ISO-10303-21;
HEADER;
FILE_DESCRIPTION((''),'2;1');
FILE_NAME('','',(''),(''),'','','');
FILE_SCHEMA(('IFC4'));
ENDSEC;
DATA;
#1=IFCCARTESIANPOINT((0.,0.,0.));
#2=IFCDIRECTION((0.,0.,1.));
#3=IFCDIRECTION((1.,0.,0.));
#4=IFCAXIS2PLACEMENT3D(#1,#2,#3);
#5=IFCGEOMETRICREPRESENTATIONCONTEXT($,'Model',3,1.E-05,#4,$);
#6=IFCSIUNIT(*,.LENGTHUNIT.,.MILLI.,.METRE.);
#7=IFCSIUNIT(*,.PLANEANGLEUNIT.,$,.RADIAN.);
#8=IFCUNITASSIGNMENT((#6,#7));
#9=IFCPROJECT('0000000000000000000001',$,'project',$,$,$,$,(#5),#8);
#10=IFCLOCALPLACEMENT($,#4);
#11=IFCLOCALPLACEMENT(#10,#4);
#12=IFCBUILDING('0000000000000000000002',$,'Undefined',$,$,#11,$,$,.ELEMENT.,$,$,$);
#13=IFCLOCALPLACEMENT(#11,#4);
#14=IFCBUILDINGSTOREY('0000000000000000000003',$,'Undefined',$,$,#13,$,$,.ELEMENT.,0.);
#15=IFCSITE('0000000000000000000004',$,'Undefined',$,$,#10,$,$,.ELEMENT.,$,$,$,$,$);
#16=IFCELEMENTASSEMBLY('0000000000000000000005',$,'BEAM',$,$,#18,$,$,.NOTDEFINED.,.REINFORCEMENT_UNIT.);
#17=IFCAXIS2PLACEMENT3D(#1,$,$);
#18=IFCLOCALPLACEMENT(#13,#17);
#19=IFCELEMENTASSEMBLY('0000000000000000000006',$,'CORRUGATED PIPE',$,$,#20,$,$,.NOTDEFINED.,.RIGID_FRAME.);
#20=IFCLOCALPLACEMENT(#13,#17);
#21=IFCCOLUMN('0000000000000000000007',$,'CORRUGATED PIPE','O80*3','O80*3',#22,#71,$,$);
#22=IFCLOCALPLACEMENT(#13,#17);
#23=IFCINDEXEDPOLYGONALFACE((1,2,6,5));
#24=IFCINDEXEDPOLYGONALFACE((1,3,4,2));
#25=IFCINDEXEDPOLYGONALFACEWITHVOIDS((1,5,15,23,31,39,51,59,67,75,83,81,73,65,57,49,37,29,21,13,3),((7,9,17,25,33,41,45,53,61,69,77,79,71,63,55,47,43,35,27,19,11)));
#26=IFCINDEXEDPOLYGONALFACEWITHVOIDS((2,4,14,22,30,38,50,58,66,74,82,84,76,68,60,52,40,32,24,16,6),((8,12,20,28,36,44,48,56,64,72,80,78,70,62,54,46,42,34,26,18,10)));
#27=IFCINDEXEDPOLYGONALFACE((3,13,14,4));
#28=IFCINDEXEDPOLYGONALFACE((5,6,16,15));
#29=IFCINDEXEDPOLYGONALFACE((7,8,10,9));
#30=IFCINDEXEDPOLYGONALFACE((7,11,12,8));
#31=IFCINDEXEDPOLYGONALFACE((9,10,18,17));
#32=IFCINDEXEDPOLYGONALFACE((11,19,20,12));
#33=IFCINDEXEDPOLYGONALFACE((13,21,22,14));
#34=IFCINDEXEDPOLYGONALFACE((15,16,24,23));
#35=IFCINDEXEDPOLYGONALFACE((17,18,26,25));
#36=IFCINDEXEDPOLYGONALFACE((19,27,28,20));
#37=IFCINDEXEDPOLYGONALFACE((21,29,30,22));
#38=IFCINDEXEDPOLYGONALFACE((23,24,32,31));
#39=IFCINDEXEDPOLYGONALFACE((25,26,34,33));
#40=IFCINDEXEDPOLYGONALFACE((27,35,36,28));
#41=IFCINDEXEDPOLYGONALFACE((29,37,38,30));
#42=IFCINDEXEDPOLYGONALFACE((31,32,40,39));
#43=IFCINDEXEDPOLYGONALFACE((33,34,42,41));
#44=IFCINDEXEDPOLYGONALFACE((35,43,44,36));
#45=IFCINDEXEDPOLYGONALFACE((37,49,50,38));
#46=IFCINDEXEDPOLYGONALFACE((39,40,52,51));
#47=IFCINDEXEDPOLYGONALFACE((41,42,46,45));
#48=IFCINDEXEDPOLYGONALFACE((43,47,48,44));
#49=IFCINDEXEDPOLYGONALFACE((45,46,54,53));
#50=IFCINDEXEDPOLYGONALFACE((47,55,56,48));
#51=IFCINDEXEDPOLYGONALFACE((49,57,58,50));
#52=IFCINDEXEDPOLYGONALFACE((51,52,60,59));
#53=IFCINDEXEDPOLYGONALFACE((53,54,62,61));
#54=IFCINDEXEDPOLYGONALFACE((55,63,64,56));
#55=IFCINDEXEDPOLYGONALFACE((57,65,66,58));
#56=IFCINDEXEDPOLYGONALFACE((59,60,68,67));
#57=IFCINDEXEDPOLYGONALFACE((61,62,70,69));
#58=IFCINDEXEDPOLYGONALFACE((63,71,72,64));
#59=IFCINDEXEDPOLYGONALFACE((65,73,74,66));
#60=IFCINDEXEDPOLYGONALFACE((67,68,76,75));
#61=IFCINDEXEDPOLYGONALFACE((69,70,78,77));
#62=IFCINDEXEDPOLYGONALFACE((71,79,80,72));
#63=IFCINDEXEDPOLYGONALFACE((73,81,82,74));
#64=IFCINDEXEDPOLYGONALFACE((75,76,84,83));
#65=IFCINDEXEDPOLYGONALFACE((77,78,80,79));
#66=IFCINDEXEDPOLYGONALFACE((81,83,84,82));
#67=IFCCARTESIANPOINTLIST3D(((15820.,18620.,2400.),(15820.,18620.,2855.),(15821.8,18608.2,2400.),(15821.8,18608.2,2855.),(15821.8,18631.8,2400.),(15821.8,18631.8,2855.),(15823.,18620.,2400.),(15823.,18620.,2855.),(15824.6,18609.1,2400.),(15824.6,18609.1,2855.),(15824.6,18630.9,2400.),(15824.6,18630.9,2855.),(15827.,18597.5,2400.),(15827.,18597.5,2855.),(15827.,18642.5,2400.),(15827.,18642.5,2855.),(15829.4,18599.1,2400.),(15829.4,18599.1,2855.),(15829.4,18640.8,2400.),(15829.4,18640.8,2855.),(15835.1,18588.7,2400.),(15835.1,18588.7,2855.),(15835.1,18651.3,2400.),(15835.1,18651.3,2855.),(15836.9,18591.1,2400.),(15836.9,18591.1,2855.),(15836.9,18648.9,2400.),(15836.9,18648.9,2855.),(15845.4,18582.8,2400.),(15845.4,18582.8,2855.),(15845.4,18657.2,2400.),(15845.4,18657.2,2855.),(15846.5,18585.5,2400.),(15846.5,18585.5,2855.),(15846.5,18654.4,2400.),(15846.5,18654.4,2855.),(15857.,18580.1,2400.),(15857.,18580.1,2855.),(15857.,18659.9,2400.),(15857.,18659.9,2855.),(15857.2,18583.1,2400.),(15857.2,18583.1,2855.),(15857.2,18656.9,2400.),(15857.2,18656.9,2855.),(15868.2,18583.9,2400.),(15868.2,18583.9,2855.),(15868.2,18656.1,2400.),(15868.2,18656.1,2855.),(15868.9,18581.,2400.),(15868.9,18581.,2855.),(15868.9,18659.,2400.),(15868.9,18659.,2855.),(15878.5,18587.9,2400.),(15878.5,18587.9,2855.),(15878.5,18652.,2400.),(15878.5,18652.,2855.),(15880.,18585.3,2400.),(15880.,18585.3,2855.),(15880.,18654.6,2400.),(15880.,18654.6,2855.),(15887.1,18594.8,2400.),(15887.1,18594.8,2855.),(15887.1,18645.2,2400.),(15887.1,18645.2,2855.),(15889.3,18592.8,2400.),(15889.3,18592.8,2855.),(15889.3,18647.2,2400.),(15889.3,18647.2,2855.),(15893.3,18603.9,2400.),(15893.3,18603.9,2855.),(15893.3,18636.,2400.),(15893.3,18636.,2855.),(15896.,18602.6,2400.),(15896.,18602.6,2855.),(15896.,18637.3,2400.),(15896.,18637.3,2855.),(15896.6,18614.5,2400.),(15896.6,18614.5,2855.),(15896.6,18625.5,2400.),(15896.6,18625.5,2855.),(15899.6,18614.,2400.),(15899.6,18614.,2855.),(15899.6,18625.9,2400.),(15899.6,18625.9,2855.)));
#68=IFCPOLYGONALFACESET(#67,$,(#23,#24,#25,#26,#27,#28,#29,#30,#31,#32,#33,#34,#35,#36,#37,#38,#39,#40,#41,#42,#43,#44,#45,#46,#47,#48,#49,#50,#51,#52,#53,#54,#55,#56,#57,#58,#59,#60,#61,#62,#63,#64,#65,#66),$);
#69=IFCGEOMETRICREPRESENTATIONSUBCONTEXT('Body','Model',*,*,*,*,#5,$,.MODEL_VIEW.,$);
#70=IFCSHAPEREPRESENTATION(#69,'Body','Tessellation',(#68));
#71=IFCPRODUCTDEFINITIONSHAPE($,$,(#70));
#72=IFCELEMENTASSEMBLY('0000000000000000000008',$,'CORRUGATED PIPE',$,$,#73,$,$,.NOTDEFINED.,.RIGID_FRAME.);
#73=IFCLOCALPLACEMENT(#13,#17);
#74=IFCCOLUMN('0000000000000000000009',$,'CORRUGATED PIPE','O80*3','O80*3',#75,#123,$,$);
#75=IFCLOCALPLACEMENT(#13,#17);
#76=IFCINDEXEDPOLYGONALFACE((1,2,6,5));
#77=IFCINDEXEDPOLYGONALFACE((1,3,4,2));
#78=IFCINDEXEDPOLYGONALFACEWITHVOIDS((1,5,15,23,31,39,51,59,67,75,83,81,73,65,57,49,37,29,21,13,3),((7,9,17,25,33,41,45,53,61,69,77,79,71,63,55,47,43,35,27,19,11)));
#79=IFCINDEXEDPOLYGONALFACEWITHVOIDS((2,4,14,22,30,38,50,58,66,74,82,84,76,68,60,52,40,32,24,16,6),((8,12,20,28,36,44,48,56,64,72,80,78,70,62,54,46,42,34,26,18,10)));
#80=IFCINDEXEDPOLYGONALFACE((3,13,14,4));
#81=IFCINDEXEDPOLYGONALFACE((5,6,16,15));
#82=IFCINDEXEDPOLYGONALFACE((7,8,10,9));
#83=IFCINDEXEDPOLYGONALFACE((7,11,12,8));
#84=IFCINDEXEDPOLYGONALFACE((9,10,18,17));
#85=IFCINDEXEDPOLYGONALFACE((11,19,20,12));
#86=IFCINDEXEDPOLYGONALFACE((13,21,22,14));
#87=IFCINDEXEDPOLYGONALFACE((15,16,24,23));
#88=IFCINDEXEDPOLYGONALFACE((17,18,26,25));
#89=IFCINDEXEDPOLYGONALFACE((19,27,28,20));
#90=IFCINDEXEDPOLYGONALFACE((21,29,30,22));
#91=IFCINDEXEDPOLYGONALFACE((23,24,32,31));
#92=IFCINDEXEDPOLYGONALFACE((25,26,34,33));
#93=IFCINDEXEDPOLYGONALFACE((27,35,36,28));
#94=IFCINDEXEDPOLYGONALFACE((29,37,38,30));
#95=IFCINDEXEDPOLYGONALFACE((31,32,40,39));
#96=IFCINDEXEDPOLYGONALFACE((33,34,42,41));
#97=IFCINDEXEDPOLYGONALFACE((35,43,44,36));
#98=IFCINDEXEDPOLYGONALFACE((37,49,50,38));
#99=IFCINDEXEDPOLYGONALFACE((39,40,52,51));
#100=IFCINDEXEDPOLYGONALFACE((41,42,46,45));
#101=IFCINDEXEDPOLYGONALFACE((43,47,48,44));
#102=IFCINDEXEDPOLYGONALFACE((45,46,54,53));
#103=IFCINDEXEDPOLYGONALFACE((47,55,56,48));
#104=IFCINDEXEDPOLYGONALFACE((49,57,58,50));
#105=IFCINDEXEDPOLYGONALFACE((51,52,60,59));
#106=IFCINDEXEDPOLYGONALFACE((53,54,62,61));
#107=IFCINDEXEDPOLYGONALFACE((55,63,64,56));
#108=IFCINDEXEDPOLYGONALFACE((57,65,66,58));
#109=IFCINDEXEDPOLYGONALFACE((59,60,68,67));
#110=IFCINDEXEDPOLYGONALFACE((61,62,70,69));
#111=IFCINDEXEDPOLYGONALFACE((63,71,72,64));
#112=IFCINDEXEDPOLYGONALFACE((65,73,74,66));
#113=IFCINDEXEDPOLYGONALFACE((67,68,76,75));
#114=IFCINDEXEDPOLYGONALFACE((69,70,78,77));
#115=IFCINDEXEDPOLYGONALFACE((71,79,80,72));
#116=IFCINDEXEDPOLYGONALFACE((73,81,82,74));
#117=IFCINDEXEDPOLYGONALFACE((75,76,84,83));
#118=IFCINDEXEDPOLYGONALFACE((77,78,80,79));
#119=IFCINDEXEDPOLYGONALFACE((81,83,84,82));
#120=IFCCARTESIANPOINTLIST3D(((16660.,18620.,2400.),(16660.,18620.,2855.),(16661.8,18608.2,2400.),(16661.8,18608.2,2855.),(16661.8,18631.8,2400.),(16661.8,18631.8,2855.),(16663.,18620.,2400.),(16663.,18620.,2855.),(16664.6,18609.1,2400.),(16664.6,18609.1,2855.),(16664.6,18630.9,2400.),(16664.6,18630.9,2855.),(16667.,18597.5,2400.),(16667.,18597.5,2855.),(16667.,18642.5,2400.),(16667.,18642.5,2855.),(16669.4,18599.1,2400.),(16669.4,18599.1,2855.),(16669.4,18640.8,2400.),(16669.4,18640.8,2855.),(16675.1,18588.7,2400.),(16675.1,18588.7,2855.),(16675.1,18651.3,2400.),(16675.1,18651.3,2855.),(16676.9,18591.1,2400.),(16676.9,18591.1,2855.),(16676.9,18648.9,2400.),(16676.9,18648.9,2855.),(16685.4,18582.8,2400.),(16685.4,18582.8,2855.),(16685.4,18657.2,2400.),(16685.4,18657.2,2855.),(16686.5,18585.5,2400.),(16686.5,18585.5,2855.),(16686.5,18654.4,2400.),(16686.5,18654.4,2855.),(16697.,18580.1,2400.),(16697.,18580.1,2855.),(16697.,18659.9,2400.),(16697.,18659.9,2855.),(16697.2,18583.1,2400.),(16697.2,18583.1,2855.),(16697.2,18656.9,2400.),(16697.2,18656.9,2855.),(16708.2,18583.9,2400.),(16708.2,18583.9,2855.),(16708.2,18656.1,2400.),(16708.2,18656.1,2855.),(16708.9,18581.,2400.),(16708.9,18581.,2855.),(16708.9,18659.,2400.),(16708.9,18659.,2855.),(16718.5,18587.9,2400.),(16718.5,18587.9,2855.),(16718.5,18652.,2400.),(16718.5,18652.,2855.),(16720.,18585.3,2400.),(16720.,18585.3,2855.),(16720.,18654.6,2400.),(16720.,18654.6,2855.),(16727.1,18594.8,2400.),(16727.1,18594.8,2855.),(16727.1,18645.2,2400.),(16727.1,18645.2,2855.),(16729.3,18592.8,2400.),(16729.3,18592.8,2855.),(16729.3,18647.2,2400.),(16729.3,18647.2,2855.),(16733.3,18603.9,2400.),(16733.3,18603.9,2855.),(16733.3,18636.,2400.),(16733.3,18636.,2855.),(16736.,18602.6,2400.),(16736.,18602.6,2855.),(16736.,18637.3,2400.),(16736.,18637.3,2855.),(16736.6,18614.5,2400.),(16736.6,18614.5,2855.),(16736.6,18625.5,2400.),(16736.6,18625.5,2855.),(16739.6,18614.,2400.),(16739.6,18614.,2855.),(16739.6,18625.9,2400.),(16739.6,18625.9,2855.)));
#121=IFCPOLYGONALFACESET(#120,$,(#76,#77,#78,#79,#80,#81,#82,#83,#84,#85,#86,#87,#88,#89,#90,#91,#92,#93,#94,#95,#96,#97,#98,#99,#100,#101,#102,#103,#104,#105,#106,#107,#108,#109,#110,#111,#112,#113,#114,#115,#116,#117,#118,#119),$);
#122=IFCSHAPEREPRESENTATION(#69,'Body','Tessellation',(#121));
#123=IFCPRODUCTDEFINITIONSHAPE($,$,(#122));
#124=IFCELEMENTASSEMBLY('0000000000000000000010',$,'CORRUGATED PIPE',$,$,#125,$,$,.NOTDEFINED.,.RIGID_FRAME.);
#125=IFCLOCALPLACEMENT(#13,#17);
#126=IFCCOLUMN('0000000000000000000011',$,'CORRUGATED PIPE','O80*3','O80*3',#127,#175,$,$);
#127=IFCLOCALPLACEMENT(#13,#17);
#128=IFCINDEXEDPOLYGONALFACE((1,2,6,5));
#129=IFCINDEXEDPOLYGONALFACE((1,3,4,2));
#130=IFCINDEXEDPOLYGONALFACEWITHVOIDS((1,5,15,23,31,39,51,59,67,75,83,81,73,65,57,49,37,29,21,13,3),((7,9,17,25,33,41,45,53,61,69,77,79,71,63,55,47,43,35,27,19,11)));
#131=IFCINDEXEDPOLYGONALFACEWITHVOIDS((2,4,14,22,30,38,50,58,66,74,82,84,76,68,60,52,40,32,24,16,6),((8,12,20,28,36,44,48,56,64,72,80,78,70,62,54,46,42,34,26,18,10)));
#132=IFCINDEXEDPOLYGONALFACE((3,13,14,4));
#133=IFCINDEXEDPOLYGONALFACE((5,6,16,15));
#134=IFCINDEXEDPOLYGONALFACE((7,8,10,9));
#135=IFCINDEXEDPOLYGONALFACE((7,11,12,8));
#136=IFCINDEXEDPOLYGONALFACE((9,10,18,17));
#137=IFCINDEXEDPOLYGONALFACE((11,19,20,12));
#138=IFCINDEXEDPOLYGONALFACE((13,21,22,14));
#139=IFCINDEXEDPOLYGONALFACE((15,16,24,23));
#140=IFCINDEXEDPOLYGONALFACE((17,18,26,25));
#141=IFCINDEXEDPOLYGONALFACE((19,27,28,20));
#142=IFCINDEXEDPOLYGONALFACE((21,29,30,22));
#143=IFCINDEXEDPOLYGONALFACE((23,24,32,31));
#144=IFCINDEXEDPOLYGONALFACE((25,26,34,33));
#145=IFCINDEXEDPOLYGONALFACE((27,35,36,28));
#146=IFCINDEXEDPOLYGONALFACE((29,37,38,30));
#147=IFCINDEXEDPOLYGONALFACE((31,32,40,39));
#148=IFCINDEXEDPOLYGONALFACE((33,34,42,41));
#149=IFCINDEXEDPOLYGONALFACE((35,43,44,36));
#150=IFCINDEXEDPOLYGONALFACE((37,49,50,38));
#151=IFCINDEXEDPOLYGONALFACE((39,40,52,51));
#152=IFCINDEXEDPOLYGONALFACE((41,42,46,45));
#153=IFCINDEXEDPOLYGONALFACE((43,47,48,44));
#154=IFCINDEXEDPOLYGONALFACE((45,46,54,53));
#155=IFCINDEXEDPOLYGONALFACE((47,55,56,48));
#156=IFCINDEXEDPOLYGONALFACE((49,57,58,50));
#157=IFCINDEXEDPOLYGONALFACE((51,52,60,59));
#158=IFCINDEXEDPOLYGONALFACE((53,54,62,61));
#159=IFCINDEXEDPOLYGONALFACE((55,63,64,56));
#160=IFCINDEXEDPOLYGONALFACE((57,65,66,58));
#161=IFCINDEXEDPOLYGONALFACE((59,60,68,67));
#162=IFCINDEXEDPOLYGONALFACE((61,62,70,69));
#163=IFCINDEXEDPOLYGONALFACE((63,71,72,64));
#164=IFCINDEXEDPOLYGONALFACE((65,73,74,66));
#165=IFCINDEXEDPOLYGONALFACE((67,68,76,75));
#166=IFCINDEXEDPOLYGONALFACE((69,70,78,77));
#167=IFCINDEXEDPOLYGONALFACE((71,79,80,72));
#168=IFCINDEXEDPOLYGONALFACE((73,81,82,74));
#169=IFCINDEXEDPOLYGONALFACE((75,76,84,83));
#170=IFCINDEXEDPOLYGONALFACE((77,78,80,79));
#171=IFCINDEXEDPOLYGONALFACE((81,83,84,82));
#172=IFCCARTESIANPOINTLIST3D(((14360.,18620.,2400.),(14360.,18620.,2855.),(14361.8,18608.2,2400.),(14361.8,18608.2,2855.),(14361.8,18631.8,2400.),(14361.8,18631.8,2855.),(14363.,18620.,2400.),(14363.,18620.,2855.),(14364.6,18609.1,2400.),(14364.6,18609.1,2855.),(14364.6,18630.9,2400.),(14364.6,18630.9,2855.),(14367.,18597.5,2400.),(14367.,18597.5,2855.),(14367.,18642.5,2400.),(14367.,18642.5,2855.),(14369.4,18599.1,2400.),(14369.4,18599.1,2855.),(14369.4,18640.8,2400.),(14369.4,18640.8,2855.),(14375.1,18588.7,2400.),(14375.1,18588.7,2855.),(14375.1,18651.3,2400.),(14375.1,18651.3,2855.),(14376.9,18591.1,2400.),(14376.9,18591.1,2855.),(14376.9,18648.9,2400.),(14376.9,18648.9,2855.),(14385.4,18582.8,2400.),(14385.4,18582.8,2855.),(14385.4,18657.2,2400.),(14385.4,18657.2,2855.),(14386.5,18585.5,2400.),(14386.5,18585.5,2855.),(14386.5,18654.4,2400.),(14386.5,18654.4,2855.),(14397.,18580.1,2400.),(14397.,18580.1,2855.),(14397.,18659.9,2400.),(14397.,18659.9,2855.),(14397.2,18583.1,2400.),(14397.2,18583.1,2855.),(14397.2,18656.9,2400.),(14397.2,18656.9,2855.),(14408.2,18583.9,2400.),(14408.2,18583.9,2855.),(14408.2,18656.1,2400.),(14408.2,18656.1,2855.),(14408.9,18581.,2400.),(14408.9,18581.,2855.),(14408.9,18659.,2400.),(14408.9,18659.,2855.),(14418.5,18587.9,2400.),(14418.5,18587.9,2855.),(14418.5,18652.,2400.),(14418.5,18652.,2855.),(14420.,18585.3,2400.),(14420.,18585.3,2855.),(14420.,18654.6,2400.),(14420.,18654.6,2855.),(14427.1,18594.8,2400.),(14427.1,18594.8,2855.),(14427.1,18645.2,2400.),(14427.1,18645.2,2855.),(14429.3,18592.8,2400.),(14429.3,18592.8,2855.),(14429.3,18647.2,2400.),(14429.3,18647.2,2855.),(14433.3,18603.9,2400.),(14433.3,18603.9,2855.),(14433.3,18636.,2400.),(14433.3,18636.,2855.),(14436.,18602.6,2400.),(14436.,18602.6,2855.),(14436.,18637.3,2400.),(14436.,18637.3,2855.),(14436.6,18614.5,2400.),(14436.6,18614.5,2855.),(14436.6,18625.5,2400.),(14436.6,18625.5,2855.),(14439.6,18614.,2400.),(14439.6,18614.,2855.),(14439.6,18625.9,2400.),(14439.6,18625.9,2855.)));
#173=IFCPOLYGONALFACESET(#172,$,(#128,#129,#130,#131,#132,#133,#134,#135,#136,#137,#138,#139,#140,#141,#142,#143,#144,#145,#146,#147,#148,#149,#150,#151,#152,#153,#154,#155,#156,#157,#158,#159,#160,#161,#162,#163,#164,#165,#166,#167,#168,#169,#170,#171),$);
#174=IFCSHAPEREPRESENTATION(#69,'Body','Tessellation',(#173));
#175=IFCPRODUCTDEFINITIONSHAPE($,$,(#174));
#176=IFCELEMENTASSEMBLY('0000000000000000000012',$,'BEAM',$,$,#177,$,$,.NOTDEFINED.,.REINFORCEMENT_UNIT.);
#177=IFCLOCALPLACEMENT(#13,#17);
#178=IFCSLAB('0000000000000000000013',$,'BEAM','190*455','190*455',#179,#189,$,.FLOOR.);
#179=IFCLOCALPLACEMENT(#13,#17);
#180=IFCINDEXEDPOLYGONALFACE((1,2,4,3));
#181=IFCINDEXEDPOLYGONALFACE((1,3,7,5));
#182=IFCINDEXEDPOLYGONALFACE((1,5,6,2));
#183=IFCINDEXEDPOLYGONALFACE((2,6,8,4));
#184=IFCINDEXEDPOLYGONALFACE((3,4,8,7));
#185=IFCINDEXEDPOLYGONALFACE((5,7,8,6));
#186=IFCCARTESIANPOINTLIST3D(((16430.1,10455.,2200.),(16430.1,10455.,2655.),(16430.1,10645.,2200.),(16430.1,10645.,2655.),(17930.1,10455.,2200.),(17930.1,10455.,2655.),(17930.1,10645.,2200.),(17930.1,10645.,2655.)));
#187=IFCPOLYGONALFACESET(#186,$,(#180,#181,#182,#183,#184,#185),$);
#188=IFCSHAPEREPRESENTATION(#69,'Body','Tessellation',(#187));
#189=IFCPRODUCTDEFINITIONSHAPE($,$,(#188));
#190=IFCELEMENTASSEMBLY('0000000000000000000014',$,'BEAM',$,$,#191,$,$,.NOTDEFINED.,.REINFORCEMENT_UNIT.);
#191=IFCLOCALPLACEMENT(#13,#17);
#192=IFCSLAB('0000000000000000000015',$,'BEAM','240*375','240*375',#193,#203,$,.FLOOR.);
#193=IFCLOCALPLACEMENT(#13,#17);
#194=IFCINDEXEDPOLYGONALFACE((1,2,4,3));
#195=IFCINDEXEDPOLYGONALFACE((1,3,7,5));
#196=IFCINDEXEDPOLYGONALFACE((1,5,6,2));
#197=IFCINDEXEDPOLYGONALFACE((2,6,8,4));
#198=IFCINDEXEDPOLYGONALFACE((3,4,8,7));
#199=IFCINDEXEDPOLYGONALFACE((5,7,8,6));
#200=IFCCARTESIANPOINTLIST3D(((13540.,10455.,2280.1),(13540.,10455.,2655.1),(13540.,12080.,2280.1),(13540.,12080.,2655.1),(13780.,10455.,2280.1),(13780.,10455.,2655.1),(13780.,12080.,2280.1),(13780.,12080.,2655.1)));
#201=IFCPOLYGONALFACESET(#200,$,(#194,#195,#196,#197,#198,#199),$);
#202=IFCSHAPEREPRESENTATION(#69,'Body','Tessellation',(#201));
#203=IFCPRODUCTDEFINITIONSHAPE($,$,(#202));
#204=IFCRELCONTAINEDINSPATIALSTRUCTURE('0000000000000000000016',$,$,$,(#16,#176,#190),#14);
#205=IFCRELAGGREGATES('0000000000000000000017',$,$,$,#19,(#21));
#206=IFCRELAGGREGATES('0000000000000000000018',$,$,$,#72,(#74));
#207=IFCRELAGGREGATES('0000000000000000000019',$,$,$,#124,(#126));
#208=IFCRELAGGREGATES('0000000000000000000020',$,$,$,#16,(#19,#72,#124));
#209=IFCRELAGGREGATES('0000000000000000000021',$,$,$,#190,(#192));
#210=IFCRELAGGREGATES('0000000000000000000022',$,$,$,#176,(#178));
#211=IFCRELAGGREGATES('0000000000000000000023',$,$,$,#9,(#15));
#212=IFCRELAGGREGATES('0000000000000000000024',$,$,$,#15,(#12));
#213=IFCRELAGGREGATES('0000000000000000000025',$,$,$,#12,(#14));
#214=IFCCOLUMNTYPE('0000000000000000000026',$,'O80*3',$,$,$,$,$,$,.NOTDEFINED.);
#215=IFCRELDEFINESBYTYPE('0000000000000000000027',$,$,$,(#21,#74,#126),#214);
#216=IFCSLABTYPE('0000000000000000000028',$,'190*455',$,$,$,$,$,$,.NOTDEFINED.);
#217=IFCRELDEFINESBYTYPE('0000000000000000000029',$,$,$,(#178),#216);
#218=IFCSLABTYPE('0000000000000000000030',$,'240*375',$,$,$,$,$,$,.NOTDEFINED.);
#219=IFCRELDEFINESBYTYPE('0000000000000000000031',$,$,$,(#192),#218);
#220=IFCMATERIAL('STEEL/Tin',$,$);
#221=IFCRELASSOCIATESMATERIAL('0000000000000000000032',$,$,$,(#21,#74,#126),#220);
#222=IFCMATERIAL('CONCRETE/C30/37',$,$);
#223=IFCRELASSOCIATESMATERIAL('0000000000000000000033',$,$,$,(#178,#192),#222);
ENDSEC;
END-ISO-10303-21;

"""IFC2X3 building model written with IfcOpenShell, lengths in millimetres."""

from ifc_helpers import new_model, si_unit, frame, origin_with_axes, origin_2d_with_axis, place, context, subcontext, project, spatial, polyline, hollow_circle, outline, extrude, material, type_object, element, aggregate, save


model = new_model("IFC2X3")

# Units and contexts
model_context = context("Model", 3, precision=1e-05, world=origin_with_axes())
body_context = subcontext(model_context, "Body", "Model", "MODEL_VIEW")
ifc_project = project(units=[si_unit("LENGTHUNIT", "METRE", prefix="MILLI"), si_unit("PLANEANGLEUNIT", "RADIAN")], contexts=[model_context])

# Site, building, storey
site_placement = place(None, origin_with_axes())
site = spatial("IfcSite", under=ifc_project, at=site_placement, Name="Undefined", CompositionType="ELEMENT")
building_placement = place(site_placement, origin_with_axes())
building = spatial("IfcBuilding", under=site, at=building_placement, Name="Undefined", CompositionType="ELEMENT")
storey_placement = place(building_placement, origin_with_axes())
storey = spatial("IfcBuildingStorey", under=building, at=storey_placement, Name="Undefined", CompositionType="ELEMENT", Elevation=0.0)

# Element assemblies, columns
assembly_1_placement = place(storey_placement, origin_with_axes())
assembly_1 = element("IfcElementAssembly", 1, at=assembly_1_placement, inside=storey, Name="BEAM", AssemblyPlace="NOTDEFINED", PredefinedType="REINFORCEMENT_UNIT")
assembly_2_placement = place(assembly_1_placement, origin_with_axes())
assembly_2 = element("IfcElementAssembly", 2, at=assembly_2_placement, Name="CORRUGATED PIPE", AssemblyPlace="NOTDEFINED", PredefinedType="RIGID_FRAME")
ifc_material_1 = material(Name="STEEL/Tin")
column_type = type_object("IfcColumnType", Name="O80*3", PredefinedType="NOTDEFINED")
column_1_placement = place(assembly_2_placement, frame((15860.0, 18620.0, 2400.0), z_axis=(0.0, 0.0, 1.0), x_axis=(0.0, 1.0, 0.0)))
column_1 = element("IfcColumn", 3, at=column_1_placement, type_object=column_type, material=ifc_material_1, Name="CORRUGATED PIPE", Description="O80*3", ObjectType="O80*3", context=body_context, shape_type="SweptSolid", body=[
    extrude(hollow_circle(Radius=40.0, WallThickness=3.0, at=origin_2d_with_axis()), frame((0.0, 0.0, 455.0), z_axis=(0.0, 0.0, -1.0), x_axis=(0.0, 1.0, 0.0)), (0.0, 0.0, 1.0), 455.0),
])
aggregate(assembly_2, [column_1])
assembly_3_placement = place(assembly_1_placement, origin_with_axes())
assembly_3 = element("IfcElementAssembly", 4, at=assembly_3_placement, Name="CORRUGATED PIPE", AssemblyPlace="NOTDEFINED", PredefinedType="RIGID_FRAME")
column_2_placement = place(assembly_3_placement, frame((16700.0, 18620.0, 2400.0), z_axis=(0.0, 0.0, 1.0), x_axis=(0.0, 1.0, 0.0)))
column_2 = element("IfcColumn", 5, at=column_2_placement, type_object=column_type, material=ifc_material_1, Name="CORRUGATED PIPE", Description="O80*3", ObjectType="O80*3", context=body_context, shape_type="SweptSolid", body=[
    extrude(hollow_circle(Radius=40.0, WallThickness=3.0, at=origin_2d_with_axis()), frame((0.0, 0.0, 455.0), z_axis=(0.0, 0.0, -1.0), x_axis=(0.0, 1.0, 0.0)), (0.0, 0.0, 1.0), 455.0),
])
aggregate(assembly_3, [column_2])
assembly_4_placement = place(assembly_1_placement, origin_with_axes())
assembly_4 = element("IfcElementAssembly", 6, at=assembly_4_placement, Name="CORRUGATED PIPE", AssemblyPlace="NOTDEFINED", PredefinedType="RIGID_FRAME")
column_3_placement = place(assembly_4_placement, frame((14400.0, 18620.0, 2400.0), z_axis=(0.0, 0.0, 1.0), x_axis=(0.0, 1.0, 0.0)))
column_3 = element("IfcColumn", 7, at=column_3_placement, type_object=column_type, material=ifc_material_1, Name="CORRUGATED PIPE", Description="O80*3", ObjectType="O80*3", context=body_context, shape_type="SweptSolid", body=[
    extrude(hollow_circle(Radius=40.0, WallThickness=3.0, at=origin_2d_with_axis()), frame((0.0, 0.0, 455.0), z_axis=(0.0, 0.0, -1.0), x_axis=(0.0, 1.0, 0.0)), (0.0, 0.0, 1.0), 455.0),
])
aggregate(assembly_4, [column_3])

# Element assemblies, slabs
assembly_5_placement = place(storey_placement, origin_with_axes())
assembly_5 = element("IfcElementAssembly", 8, at=assembly_5_placement, inside=storey, Name="BEAM", AssemblyPlace="NOTDEFINED", PredefinedType="REINFORCEMENT_UNIT")
ifc_material_2 = material(Name="CONCRETE/C30/37")
slab_type_1 = type_object("IfcSlabType", Name="190*455", PredefinedType="NOTDEFINED")
slab_1_placement = place(assembly_5_placement, frame((16430.1, 10550.0, 2200.0), z_axis=(0.0, 1.0, 0.0), x_axis=(0.0, 0.0, 1.0)))
slab_1 = element("IfcSlab", 9, at=slab_1_placement, type_object=slab_type_1, material=ifc_material_2, Name="BEAM", Description="190*455", ObjectType="190*455", PredefinedType="FLOOR", context=body_context, shape_type="SweptSolid", body=[
    extrude(outline(polyline([(0.0, 0.0), (455.0, 0.0), (455.0, 1500.0), (0.0, 1500.0), (0.0, 0.0)])), frame((0.0, 0.0, -95.0), z_axis=(0.0, 0.0, 1.0), x_axis=(1.0, 0.0, 0.0)), (0.0, 0.0, 1.0), 190.0),
])
assembly_6_placement = place(storey_placement, origin_with_axes())
assembly_6 = element("IfcElementAssembly", 10, at=assembly_6_placement, inside=storey, Name="BEAM", AssemblyPlace="NOTDEFINED", PredefinedType="REINFORCEMENT_UNIT")
slab_type_2 = type_object("IfcSlabType", Name="240*375", PredefinedType="NOTDEFINED")
slab_2_placement = place(assembly_6_placement, frame((13660.0, 12080.0, 2280.1), z_axis=(1.0, 0.0, 0.0), x_axis=(0.0, 0.0, 1.0)))
slab_2 = element("IfcSlab", 11, at=slab_2_placement, type_object=slab_type_2, material=ifc_material_2, Name="BEAM", Description="240*375", ObjectType="240*375", PredefinedType="FLOOR", context=body_context, shape_type="SweptSolid", body=[
    extrude(outline(polyline([(0.0, 0.0), (375.0, 0.0), (375.0, 1625.0), (0.0, 1625.0), (0.0, 0.0)])), frame((0.0, 0.0, -120.0), z_axis=(0.0, 0.0, 1.0), x_axis=(1.0, 0.0, 0.0)), (0.0, 0.0, 1.0), 240.0),
])

aggregate(assembly_1, [assembly_2, assembly_3, assembly_4])
aggregate(assembly_6, [slab_2])

aggregate(assembly_5, [slab_1])

save(model, "model.ifc")
